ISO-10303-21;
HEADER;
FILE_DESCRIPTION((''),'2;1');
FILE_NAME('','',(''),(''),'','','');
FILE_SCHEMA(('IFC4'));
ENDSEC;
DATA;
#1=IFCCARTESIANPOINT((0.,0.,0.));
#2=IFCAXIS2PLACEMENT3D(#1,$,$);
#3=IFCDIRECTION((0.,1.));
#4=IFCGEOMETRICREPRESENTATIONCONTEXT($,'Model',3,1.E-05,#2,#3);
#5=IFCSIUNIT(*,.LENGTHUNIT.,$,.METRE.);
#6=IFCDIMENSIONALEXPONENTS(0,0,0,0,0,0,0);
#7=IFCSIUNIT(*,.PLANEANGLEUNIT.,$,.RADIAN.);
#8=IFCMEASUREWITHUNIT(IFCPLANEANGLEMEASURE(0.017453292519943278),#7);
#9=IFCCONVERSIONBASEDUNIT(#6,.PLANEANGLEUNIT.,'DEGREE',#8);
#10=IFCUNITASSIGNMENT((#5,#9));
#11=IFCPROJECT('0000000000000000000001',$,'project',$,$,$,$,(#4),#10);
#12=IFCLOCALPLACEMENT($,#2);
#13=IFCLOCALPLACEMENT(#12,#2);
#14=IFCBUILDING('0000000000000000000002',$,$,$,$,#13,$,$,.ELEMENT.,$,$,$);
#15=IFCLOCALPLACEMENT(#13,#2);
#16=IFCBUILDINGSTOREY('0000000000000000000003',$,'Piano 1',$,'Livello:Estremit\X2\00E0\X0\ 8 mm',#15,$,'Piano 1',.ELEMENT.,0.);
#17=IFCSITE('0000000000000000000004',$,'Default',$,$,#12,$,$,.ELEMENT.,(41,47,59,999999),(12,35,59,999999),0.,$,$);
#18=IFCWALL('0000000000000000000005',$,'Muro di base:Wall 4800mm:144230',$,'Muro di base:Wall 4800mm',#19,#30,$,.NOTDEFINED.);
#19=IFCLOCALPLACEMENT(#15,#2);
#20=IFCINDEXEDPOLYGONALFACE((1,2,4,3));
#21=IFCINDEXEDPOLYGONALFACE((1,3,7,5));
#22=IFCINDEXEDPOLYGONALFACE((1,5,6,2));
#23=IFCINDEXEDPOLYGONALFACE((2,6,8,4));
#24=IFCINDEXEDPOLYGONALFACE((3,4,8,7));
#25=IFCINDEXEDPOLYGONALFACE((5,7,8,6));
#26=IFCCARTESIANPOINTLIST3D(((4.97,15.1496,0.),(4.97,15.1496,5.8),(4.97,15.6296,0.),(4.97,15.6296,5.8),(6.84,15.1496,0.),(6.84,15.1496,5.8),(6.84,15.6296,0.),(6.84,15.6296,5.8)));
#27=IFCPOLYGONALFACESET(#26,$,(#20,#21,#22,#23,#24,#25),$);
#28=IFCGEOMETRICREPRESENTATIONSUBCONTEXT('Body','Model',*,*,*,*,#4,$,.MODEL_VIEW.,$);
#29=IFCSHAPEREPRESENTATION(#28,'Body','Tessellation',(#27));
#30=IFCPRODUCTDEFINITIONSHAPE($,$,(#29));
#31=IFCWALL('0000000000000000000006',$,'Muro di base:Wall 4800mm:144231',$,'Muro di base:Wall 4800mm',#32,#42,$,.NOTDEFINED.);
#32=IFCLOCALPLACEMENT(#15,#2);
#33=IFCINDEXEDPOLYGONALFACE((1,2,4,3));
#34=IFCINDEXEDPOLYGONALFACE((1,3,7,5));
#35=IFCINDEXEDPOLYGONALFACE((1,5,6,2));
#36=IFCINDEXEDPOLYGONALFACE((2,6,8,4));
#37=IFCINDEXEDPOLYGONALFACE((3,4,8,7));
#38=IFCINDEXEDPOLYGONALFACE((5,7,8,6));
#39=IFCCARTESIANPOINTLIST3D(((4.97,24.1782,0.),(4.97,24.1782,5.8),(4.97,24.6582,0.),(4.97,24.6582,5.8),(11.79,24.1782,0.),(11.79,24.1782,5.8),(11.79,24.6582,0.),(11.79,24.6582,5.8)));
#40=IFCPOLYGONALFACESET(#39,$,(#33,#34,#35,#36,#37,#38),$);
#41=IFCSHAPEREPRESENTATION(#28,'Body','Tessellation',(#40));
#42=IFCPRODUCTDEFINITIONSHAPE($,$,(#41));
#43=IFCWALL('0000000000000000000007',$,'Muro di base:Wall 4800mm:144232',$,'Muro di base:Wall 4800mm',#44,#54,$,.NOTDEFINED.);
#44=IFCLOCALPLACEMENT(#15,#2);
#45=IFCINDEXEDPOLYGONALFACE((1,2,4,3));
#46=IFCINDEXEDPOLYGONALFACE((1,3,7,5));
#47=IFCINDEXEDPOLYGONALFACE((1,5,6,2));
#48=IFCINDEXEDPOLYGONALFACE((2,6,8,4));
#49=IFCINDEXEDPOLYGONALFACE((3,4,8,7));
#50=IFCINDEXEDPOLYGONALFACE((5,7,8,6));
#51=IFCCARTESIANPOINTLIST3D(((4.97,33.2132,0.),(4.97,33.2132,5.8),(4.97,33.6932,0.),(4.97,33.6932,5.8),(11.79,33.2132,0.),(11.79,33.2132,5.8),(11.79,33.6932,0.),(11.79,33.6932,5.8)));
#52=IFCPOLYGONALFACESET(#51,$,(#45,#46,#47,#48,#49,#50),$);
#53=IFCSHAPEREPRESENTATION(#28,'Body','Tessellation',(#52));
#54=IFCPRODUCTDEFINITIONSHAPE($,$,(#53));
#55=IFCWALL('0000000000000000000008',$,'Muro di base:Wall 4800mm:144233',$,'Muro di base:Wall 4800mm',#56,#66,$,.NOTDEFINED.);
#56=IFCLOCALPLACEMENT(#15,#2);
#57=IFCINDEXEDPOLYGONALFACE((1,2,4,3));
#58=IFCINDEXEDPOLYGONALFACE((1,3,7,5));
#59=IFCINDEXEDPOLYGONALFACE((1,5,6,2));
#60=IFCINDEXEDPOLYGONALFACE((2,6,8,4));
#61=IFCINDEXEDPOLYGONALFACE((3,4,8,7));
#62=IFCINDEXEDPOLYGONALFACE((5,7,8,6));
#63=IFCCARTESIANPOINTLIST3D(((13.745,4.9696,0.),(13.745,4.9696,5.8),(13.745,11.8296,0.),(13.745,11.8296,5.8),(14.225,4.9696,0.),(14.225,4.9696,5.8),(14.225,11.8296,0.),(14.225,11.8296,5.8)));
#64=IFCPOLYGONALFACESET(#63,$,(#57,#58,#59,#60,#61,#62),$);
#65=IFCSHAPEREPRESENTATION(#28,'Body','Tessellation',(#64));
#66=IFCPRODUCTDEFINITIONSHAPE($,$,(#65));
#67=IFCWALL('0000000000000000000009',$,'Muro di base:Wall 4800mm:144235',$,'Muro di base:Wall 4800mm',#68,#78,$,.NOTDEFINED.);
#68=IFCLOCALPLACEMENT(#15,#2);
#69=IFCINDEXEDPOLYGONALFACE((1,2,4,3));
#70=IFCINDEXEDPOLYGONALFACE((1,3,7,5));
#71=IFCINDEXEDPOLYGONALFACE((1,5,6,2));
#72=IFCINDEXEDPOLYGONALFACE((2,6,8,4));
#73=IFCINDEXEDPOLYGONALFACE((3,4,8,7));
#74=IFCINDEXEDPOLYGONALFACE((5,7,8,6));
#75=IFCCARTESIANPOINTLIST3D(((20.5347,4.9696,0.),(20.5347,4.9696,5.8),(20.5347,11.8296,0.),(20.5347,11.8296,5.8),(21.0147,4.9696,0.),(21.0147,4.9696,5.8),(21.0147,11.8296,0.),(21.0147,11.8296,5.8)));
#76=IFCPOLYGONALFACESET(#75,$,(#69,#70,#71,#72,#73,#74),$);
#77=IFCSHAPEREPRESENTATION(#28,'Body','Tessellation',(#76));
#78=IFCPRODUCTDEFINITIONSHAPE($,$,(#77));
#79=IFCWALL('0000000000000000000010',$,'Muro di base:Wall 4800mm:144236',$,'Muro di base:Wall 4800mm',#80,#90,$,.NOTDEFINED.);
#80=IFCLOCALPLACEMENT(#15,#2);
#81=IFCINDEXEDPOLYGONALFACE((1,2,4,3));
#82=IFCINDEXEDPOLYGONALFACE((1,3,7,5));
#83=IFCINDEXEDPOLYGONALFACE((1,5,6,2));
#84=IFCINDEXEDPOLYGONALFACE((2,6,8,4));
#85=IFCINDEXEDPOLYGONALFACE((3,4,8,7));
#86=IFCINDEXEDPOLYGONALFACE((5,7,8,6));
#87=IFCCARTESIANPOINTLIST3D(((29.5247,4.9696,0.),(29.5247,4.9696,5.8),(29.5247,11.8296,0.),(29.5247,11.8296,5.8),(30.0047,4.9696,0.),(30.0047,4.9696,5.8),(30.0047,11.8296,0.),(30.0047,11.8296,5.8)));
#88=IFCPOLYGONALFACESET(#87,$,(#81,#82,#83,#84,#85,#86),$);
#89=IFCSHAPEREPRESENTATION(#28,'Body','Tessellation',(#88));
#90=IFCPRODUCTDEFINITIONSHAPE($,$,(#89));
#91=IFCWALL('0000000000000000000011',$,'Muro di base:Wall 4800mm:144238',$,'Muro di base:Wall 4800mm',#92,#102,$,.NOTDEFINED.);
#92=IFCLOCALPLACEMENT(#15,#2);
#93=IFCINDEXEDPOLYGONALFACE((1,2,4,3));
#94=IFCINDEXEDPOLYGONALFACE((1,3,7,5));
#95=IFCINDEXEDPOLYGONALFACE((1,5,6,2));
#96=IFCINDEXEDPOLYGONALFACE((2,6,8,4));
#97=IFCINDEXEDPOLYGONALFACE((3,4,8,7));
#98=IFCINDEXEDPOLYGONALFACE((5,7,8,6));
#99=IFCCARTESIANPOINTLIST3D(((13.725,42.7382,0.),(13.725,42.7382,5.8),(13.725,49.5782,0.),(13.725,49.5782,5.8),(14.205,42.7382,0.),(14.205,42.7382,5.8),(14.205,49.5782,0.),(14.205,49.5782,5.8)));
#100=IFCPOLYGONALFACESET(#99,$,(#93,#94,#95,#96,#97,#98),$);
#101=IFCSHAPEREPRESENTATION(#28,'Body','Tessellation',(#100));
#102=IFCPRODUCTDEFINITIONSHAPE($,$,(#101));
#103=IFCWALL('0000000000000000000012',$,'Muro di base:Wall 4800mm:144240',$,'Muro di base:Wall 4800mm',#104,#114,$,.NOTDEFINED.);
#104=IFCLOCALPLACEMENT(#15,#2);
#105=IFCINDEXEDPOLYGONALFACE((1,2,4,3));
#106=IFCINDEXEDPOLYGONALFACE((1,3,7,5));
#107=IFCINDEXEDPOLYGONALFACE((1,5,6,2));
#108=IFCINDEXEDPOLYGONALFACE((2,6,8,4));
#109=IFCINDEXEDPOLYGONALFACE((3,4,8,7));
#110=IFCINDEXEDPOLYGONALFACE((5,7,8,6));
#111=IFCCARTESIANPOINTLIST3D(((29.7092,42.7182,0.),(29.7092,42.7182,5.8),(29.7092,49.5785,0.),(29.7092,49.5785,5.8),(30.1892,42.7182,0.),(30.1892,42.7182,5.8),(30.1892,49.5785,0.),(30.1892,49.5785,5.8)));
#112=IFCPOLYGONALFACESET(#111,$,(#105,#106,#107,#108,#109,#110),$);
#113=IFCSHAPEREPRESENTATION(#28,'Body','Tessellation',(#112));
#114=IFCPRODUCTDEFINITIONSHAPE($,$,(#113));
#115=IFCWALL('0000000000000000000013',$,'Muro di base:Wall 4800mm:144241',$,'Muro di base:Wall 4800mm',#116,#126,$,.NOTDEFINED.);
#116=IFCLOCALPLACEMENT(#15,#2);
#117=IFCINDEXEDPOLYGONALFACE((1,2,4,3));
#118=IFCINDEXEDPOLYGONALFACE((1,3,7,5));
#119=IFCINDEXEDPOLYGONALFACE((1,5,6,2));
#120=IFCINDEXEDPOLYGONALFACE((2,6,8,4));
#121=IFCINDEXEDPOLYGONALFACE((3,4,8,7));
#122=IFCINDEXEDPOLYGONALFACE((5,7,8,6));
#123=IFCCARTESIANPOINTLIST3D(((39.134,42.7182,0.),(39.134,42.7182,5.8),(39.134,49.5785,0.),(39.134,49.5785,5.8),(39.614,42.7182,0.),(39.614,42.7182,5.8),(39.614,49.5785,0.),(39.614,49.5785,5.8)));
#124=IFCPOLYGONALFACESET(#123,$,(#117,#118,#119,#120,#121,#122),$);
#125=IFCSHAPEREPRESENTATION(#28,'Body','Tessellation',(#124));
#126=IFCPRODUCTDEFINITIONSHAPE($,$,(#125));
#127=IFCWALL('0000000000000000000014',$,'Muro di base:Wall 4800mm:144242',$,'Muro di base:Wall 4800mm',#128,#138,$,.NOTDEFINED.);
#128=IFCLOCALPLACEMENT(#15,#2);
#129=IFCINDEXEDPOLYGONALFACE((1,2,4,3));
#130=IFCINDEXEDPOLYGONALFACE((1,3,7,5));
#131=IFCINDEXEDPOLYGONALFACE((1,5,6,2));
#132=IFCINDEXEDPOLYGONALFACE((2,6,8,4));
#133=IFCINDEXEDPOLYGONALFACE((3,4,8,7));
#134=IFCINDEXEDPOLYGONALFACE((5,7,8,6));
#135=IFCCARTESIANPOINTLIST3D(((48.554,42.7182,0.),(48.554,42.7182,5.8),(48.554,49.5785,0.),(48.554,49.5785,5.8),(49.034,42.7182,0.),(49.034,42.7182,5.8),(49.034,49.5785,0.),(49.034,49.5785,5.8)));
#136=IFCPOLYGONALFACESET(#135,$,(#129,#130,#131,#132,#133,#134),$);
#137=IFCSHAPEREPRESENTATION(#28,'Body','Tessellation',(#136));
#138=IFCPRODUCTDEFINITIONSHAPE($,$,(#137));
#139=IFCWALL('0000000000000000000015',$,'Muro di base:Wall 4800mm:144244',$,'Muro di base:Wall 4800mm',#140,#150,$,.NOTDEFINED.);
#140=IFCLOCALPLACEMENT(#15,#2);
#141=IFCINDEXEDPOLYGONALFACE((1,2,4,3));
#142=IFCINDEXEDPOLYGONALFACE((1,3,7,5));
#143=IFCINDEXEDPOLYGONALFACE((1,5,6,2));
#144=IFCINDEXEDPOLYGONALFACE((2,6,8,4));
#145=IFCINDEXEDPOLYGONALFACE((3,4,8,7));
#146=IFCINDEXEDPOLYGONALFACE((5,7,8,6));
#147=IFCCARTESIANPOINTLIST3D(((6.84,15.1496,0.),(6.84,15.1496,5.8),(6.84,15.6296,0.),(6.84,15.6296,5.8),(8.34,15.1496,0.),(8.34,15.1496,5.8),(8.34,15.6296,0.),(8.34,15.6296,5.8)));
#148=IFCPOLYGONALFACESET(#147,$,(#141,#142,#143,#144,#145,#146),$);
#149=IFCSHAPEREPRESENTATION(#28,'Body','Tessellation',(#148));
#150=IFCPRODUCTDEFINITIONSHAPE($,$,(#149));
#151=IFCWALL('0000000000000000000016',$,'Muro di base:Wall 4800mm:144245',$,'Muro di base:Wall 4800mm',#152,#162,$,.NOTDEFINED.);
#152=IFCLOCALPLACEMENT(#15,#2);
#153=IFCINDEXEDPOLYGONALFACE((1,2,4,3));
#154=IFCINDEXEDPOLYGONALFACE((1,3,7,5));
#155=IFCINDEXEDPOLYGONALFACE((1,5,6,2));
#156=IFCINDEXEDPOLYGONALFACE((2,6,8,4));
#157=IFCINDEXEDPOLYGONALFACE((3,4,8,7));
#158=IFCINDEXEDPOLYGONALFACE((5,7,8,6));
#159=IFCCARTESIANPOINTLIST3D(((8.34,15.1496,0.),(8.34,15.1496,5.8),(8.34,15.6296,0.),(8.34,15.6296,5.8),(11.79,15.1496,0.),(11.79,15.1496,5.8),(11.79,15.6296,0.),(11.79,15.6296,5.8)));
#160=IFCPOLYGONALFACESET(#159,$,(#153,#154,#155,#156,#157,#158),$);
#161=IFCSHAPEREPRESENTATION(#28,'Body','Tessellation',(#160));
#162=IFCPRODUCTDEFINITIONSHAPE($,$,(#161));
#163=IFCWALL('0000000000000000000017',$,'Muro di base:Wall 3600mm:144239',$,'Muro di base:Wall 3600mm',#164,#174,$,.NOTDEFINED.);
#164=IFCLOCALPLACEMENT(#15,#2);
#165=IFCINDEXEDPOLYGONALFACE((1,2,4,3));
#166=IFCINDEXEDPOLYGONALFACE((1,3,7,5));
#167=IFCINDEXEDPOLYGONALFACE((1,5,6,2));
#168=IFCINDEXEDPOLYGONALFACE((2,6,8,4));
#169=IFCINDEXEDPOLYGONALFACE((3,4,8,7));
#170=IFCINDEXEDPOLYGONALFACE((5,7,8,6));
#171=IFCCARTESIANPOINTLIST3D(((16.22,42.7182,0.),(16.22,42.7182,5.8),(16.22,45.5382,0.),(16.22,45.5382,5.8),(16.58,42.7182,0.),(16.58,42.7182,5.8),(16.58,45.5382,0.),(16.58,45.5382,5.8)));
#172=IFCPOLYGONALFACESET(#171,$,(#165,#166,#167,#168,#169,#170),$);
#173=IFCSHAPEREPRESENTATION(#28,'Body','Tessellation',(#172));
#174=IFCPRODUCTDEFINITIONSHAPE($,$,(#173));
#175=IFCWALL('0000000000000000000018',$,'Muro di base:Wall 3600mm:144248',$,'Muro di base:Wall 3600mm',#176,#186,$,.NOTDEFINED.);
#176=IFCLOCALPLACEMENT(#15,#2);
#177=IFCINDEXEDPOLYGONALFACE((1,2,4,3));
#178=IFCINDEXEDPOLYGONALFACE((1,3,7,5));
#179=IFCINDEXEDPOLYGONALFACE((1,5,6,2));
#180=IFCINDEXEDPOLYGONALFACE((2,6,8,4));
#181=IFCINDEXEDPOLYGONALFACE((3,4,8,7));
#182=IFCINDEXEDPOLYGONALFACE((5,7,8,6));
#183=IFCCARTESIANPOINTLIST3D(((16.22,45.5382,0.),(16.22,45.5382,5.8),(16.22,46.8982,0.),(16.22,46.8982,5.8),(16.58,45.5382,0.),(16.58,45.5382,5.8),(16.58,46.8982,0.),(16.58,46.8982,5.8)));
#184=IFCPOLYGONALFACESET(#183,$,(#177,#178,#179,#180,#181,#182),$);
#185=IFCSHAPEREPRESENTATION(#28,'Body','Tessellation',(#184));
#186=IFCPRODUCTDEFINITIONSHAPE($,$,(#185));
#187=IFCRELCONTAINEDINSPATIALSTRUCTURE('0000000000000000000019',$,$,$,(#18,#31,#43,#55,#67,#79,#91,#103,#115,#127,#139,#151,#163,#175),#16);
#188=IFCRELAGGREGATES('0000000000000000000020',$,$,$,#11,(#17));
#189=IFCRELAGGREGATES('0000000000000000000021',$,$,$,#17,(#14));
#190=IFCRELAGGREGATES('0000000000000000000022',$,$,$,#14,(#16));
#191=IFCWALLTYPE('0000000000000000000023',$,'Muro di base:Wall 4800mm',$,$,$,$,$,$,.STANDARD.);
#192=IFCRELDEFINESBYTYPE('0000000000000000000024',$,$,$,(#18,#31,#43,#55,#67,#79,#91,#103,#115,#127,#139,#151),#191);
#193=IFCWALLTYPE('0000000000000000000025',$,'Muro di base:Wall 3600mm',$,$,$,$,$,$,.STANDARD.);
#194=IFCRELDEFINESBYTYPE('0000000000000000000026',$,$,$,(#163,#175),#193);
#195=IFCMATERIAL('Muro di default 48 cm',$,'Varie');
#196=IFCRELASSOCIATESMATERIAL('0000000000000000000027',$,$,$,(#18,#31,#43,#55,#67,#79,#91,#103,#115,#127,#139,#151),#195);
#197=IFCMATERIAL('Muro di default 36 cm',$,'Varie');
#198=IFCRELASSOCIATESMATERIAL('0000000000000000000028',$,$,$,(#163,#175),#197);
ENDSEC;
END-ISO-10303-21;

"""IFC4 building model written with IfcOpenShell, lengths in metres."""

from ifc_helpers import new_model, entity, si_unit, converted_unit, direction, frame, origin, place, context, subcontext, project, spatial, indexed_curve, outline, extrude, material, type_object, element, save


model = new_model("IFC4")

# Units and contexts
model_context = context("Model", 3, precision=1e-05, world=origin(), true_north=direction((0.0, 1.0)))
body_context = subcontext(model_context, "Body", "Model", "MODEL_VIEW")
ifc_project = project(units=[si_unit("LENGTHUNIT", "METRE"), converted_unit("PLANEANGLEUNIT", "DEGREE", entity("IfcPlaneAngleMeasure", 0.017453292519943278), si_unit("PLANEANGLEUNIT", "RADIAN"), dimensions=[0, 0, 0, 0, 0, 0, 0])], contexts=[model_context])

# Site, building, storey
site_placement = place(None, origin())
site = spatial("IfcSite", under=ifc_project, at=site_placement, Name="Default", CompositionType="ELEMENT", RefLatitude=(41, 47, 59, 999999), RefLongitude=(12, 35, 59, 999999), RefElevation=0.0)
building_placement = place(site_placement, origin())
building = spatial("IfcBuilding", under=site, at=building_placement, CompositionType="ELEMENT")
storey_placement = place(building_placement, origin())
storey = spatial("IfcBuildingStorey", under=building, at=storey_placement, Name="Piano 1", ObjectType="Livello:Estremità 8 mm", LongName="Piano 1", CompositionType="ELEMENT", Elevation=0.0)

# Walls
ifc_material_1 = material(Name="Muro di default 48 cm", Category="Varie")
wall_type_1 = type_object("IfcWallType", Name="Muro di base:Wall 4800mm", PredefinedType="STANDARD")
wall_1_placement = place(storey_placement, frame((4.97, 15.3896, 0.0)))
element("IfcWall", 1, at=wall_1_placement, inside=storey, type_object=wall_type_1, material=ifc_material_1, Name="Muro di base:Wall 4800mm:144230", ObjectType="Muro di base:Wall 4800mm", PredefinedType="NOTDEFINED", context=body_context, shape_type="SweptSolid", body=[
    extrude(outline(indexed_curve([(1.87, 0.24), (0.0, 0.24), (0.0, -0.24), (1.87, -0.24), (1.87, 0.24)], self_intersect=False)), origin(), (0.0, 0.0, 1.0), 5.8),
])
wall_2_placement = place(storey_placement, frame((4.97, 24.4182, 0.0)))
element("IfcWall", 2, at=wall_2_placement, inside=storey, type_object=wall_type_1, material=ifc_material_1, Name="Muro di base:Wall 4800mm:144231", ObjectType="Muro di base:Wall 4800mm", PredefinedType="NOTDEFINED", context=body_context, shape_type="SweptSolid", body=[
    extrude(outline(indexed_curve([(6.82, 0.24), (0.0, 0.24), (0.0, -0.24), (6.82, -0.24), (6.82, 0.24)], self_intersect=False)), origin(), (0.0, 0.0, 1.0), 5.8),
])
wall_3_placement = place(storey_placement, frame((4.97, 33.4532, 0.0)))
element("IfcWall", 3, at=wall_3_placement, inside=storey, type_object=wall_type_1, material=ifc_material_1, Name="Muro di base:Wall 4800mm:144232", ObjectType="Muro di base:Wall 4800mm", PredefinedType="NOTDEFINED", context=body_context, shape_type="SweptSolid", body=[
    extrude(outline(indexed_curve([(6.82, 0.24), (0.0, 0.24), (0.0, -0.24), (6.82, -0.24), (6.82, 0.24)], self_intersect=False)), origin(), (0.0, 0.0, 1.0), 5.8),
])
wall_4_placement = place(storey_placement, frame((13.985, 4.9696, 0.0), z_axis=(0.0, 0.0, 1.0), x_axis=(0.0, 1.0, 0.0)))
element("IfcWall", 4, at=wall_4_placement, inside=storey, type_object=wall_type_1, material=ifc_material_1, Name="Muro di base:Wall 4800mm:144233", ObjectType="Muro di base:Wall 4800mm", PredefinedType="NOTDEFINED", context=body_context, shape_type="SweptSolid", body=[
    extrude(outline(indexed_curve([(6.86, 0.24), (0.0, 0.24), (0.0, -0.24), (6.86, -0.24), (6.86, 0.24)], self_intersect=False)), origin(), (0.0, 0.0, 1.0), 5.8),
])
for number, where, z_axis, x_axis, name in (
    (5, (20.7747, 4.9696, 0.0), (0.0, 0.0, 1.0), (0.0, 1.0, 0.0), "Muro di base:Wall 4800mm:144235"),
    (6, (29.7647, 4.9696, 0.0), (0.0, 0.0, 1.0), (0.0, 1.0, 0.0), "Muro di base:Wall 4800mm:144236"),
):
    element("IfcWall", number, at=place(storey_placement, frame(where, z_axis=z_axis, x_axis=x_axis)), inside=storey, type_object=wall_type_1, material=ifc_material_1, Name=name, ObjectType="Muro di base:Wall 4800mm", PredefinedType="NOTDEFINED", context=body_context, shape_type="SweptSolid", body=[
        extrude(outline(indexed_curve([(6.86, 0.24), (0.0, 0.24), (0.0, -0.24), (6.86, -0.24), (6.86, 0.24)], self_intersect=False)), origin(), (0.0, 0.0, 1.0), 5.8),
    ])
wall_5_placement = place(storey_placement, frame((13.965, 42.7382, 0.0), z_axis=(0.0, 0.0, 1.0), x_axis=(0.0, 1.0, 0.0)))
element("IfcWall", 7, at=wall_5_placement, inside=storey, type_object=wall_type_1, material=ifc_material_1, Name="Muro di base:Wall 4800mm:144238", ObjectType="Muro di base:Wall 4800mm", PredefinedType="NOTDEFINED", context=body_context, shape_type="SweptSolid", body=[
    extrude(outline(indexed_curve([(6.84, 0.24), (0.0, 0.24), (0.0, -0.24), (6.84, -0.24), (6.84, 0.24)], self_intersect=False)), origin(), (0.0, 0.0, 1.0), 5.8),
])
wall_6_placement = place(storey_placement, frame((29.9492, 42.7182, 0.0), z_axis=(0.0, 0.0, 1.0), x_axis=(0.0, 1.0, 0.0)))
element("IfcWall", 8, at=wall_6_placement, inside=storey, type_object=wall_type_1, material=ifc_material_1, Name="Muro di base:Wall 4800mm:144240", ObjectType="Muro di base:Wall 4800mm", PredefinedType="NOTDEFINED", context=body_context, shape_type="SweptSolid", body=[
    extrude(outline(indexed_curve([(6.8603, 0.24), (0.0, 0.24), (0.0, -0.24), (6.8603, -0.24), (6.8603, 0.24)], self_intersect=False)), origin(), (0.0, 0.0, 1.0), 5.8),
])
for number, where, z_axis, x_axis, name in (
    (9, (39.374, 42.7182, 0.0), (0.0, 0.0, 1.0), (0.0, 1.0, 0.0), "Muro di base:Wall 4800mm:144241"),
    (10, (48.794, 42.7182, 0.0), (0.0, 0.0, 1.0), (0.0, 1.0, 0.0), "Muro di base:Wall 4800mm:144242"),
):
    element("IfcWall", number, at=place(storey_placement, frame(where, z_axis=z_axis, x_axis=x_axis)), inside=storey, type_object=wall_type_1, material=ifc_material_1, Name=name, ObjectType="Muro di base:Wall 4800mm", PredefinedType="NOTDEFINED", context=body_context, shape_type="SweptSolid", body=[
        extrude(outline(indexed_curve([(6.8603, 0.24), (0.0, 0.24), (0.0, -0.24), (6.8603, -0.24), (6.8603, 0.24)], self_intersect=False)), origin(), (0.0, 0.0, 1.0), 5.8),
    ])
wall_7_placement = place(storey_placement, frame((6.84, 15.3896, 0.0)))
element("IfcWall", 11, at=wall_7_placement, inside=storey, type_object=wall_type_1, material=ifc_material_1, Name="Muro di base:Wall 4800mm:144244", ObjectType="Muro di base:Wall 4800mm", PredefinedType="NOTDEFINED", context=body_context, shape_type="SweptSolid", body=[
    extrude(outline(indexed_curve([(1.5, 0.24), (0.0, 0.24), (0.0, -0.24), (1.5, -0.24), (1.5, 0.24)], self_intersect=False)), origin(), (0.0, 0.0, 1.0), 5.8),
])
wall_8_placement = place(storey_placement, frame((8.34, 15.3896, 0.0)))
element("IfcWall", 12, at=wall_8_placement, inside=storey, type_object=wall_type_1, material=ifc_material_1, Name="Muro di base:Wall 4800mm:144245", ObjectType="Muro di base:Wall 4800mm", PredefinedType="NOTDEFINED", context=body_context, shape_type="SweptSolid", body=[
    extrude(outline(indexed_curve([(3.45, 0.24), (0.0, 0.24), (0.0, -0.24), (3.45, -0.24), (3.45, 0.24)], self_intersect=False)), origin(), (0.0, 0.0, 1.0), 5.8),
])
ifc_material_2 = material(Name="Muro di default 36 cm", Category="Varie")
wall_type_2 = type_object("IfcWallType", Name="Muro di base:Wall 3600mm", PredefinedType="STANDARD")
wall_9_placement = place(storey_placement, frame((16.4, 42.7182, 0.0), z_axis=(0.0, 0.0, 1.0), x_axis=(0.0, 1.0, 0.0)))
element("IfcWall", 13, at=wall_9_placement, inside=storey, type_object=wall_type_2, material=ifc_material_2, Name="Muro di base:Wall 3600mm:144239", ObjectType="Muro di base:Wall 3600mm", PredefinedType="NOTDEFINED", context=body_context, shape_type="SweptSolid", body=[
    extrude(outline(indexed_curve([(2.82, 0.18), (0.0, 0.18), (0.0, -0.18), (2.82, -0.18), (2.82, 0.18)], self_intersect=False)), origin(), (0.0, 0.0, 1.0), 5.8),
])
wall_10_placement = place(storey_placement, frame((16.4, 45.5382, 0.0), z_axis=(0.0, 0.0, 1.0), x_axis=(0.0, 1.0, 0.0)))
element("IfcWall", 14, at=wall_10_placement, inside=storey, type_object=wall_type_2, material=ifc_material_2, Name="Muro di base:Wall 3600mm:144248", ObjectType="Muro di base:Wall 3600mm", PredefinedType="NOTDEFINED", context=body_context, shape_type="SweptSolid", body=[
    extrude(outline(indexed_curve([(1.36, 0.18), (0.0, 0.18), (0.0, -0.18), (1.36, -0.18), (1.36, 0.18)], self_intersect=False)), origin(), (0.0, 0.0, 1.0), 5.8),
])

save(model, "model.ifc")
